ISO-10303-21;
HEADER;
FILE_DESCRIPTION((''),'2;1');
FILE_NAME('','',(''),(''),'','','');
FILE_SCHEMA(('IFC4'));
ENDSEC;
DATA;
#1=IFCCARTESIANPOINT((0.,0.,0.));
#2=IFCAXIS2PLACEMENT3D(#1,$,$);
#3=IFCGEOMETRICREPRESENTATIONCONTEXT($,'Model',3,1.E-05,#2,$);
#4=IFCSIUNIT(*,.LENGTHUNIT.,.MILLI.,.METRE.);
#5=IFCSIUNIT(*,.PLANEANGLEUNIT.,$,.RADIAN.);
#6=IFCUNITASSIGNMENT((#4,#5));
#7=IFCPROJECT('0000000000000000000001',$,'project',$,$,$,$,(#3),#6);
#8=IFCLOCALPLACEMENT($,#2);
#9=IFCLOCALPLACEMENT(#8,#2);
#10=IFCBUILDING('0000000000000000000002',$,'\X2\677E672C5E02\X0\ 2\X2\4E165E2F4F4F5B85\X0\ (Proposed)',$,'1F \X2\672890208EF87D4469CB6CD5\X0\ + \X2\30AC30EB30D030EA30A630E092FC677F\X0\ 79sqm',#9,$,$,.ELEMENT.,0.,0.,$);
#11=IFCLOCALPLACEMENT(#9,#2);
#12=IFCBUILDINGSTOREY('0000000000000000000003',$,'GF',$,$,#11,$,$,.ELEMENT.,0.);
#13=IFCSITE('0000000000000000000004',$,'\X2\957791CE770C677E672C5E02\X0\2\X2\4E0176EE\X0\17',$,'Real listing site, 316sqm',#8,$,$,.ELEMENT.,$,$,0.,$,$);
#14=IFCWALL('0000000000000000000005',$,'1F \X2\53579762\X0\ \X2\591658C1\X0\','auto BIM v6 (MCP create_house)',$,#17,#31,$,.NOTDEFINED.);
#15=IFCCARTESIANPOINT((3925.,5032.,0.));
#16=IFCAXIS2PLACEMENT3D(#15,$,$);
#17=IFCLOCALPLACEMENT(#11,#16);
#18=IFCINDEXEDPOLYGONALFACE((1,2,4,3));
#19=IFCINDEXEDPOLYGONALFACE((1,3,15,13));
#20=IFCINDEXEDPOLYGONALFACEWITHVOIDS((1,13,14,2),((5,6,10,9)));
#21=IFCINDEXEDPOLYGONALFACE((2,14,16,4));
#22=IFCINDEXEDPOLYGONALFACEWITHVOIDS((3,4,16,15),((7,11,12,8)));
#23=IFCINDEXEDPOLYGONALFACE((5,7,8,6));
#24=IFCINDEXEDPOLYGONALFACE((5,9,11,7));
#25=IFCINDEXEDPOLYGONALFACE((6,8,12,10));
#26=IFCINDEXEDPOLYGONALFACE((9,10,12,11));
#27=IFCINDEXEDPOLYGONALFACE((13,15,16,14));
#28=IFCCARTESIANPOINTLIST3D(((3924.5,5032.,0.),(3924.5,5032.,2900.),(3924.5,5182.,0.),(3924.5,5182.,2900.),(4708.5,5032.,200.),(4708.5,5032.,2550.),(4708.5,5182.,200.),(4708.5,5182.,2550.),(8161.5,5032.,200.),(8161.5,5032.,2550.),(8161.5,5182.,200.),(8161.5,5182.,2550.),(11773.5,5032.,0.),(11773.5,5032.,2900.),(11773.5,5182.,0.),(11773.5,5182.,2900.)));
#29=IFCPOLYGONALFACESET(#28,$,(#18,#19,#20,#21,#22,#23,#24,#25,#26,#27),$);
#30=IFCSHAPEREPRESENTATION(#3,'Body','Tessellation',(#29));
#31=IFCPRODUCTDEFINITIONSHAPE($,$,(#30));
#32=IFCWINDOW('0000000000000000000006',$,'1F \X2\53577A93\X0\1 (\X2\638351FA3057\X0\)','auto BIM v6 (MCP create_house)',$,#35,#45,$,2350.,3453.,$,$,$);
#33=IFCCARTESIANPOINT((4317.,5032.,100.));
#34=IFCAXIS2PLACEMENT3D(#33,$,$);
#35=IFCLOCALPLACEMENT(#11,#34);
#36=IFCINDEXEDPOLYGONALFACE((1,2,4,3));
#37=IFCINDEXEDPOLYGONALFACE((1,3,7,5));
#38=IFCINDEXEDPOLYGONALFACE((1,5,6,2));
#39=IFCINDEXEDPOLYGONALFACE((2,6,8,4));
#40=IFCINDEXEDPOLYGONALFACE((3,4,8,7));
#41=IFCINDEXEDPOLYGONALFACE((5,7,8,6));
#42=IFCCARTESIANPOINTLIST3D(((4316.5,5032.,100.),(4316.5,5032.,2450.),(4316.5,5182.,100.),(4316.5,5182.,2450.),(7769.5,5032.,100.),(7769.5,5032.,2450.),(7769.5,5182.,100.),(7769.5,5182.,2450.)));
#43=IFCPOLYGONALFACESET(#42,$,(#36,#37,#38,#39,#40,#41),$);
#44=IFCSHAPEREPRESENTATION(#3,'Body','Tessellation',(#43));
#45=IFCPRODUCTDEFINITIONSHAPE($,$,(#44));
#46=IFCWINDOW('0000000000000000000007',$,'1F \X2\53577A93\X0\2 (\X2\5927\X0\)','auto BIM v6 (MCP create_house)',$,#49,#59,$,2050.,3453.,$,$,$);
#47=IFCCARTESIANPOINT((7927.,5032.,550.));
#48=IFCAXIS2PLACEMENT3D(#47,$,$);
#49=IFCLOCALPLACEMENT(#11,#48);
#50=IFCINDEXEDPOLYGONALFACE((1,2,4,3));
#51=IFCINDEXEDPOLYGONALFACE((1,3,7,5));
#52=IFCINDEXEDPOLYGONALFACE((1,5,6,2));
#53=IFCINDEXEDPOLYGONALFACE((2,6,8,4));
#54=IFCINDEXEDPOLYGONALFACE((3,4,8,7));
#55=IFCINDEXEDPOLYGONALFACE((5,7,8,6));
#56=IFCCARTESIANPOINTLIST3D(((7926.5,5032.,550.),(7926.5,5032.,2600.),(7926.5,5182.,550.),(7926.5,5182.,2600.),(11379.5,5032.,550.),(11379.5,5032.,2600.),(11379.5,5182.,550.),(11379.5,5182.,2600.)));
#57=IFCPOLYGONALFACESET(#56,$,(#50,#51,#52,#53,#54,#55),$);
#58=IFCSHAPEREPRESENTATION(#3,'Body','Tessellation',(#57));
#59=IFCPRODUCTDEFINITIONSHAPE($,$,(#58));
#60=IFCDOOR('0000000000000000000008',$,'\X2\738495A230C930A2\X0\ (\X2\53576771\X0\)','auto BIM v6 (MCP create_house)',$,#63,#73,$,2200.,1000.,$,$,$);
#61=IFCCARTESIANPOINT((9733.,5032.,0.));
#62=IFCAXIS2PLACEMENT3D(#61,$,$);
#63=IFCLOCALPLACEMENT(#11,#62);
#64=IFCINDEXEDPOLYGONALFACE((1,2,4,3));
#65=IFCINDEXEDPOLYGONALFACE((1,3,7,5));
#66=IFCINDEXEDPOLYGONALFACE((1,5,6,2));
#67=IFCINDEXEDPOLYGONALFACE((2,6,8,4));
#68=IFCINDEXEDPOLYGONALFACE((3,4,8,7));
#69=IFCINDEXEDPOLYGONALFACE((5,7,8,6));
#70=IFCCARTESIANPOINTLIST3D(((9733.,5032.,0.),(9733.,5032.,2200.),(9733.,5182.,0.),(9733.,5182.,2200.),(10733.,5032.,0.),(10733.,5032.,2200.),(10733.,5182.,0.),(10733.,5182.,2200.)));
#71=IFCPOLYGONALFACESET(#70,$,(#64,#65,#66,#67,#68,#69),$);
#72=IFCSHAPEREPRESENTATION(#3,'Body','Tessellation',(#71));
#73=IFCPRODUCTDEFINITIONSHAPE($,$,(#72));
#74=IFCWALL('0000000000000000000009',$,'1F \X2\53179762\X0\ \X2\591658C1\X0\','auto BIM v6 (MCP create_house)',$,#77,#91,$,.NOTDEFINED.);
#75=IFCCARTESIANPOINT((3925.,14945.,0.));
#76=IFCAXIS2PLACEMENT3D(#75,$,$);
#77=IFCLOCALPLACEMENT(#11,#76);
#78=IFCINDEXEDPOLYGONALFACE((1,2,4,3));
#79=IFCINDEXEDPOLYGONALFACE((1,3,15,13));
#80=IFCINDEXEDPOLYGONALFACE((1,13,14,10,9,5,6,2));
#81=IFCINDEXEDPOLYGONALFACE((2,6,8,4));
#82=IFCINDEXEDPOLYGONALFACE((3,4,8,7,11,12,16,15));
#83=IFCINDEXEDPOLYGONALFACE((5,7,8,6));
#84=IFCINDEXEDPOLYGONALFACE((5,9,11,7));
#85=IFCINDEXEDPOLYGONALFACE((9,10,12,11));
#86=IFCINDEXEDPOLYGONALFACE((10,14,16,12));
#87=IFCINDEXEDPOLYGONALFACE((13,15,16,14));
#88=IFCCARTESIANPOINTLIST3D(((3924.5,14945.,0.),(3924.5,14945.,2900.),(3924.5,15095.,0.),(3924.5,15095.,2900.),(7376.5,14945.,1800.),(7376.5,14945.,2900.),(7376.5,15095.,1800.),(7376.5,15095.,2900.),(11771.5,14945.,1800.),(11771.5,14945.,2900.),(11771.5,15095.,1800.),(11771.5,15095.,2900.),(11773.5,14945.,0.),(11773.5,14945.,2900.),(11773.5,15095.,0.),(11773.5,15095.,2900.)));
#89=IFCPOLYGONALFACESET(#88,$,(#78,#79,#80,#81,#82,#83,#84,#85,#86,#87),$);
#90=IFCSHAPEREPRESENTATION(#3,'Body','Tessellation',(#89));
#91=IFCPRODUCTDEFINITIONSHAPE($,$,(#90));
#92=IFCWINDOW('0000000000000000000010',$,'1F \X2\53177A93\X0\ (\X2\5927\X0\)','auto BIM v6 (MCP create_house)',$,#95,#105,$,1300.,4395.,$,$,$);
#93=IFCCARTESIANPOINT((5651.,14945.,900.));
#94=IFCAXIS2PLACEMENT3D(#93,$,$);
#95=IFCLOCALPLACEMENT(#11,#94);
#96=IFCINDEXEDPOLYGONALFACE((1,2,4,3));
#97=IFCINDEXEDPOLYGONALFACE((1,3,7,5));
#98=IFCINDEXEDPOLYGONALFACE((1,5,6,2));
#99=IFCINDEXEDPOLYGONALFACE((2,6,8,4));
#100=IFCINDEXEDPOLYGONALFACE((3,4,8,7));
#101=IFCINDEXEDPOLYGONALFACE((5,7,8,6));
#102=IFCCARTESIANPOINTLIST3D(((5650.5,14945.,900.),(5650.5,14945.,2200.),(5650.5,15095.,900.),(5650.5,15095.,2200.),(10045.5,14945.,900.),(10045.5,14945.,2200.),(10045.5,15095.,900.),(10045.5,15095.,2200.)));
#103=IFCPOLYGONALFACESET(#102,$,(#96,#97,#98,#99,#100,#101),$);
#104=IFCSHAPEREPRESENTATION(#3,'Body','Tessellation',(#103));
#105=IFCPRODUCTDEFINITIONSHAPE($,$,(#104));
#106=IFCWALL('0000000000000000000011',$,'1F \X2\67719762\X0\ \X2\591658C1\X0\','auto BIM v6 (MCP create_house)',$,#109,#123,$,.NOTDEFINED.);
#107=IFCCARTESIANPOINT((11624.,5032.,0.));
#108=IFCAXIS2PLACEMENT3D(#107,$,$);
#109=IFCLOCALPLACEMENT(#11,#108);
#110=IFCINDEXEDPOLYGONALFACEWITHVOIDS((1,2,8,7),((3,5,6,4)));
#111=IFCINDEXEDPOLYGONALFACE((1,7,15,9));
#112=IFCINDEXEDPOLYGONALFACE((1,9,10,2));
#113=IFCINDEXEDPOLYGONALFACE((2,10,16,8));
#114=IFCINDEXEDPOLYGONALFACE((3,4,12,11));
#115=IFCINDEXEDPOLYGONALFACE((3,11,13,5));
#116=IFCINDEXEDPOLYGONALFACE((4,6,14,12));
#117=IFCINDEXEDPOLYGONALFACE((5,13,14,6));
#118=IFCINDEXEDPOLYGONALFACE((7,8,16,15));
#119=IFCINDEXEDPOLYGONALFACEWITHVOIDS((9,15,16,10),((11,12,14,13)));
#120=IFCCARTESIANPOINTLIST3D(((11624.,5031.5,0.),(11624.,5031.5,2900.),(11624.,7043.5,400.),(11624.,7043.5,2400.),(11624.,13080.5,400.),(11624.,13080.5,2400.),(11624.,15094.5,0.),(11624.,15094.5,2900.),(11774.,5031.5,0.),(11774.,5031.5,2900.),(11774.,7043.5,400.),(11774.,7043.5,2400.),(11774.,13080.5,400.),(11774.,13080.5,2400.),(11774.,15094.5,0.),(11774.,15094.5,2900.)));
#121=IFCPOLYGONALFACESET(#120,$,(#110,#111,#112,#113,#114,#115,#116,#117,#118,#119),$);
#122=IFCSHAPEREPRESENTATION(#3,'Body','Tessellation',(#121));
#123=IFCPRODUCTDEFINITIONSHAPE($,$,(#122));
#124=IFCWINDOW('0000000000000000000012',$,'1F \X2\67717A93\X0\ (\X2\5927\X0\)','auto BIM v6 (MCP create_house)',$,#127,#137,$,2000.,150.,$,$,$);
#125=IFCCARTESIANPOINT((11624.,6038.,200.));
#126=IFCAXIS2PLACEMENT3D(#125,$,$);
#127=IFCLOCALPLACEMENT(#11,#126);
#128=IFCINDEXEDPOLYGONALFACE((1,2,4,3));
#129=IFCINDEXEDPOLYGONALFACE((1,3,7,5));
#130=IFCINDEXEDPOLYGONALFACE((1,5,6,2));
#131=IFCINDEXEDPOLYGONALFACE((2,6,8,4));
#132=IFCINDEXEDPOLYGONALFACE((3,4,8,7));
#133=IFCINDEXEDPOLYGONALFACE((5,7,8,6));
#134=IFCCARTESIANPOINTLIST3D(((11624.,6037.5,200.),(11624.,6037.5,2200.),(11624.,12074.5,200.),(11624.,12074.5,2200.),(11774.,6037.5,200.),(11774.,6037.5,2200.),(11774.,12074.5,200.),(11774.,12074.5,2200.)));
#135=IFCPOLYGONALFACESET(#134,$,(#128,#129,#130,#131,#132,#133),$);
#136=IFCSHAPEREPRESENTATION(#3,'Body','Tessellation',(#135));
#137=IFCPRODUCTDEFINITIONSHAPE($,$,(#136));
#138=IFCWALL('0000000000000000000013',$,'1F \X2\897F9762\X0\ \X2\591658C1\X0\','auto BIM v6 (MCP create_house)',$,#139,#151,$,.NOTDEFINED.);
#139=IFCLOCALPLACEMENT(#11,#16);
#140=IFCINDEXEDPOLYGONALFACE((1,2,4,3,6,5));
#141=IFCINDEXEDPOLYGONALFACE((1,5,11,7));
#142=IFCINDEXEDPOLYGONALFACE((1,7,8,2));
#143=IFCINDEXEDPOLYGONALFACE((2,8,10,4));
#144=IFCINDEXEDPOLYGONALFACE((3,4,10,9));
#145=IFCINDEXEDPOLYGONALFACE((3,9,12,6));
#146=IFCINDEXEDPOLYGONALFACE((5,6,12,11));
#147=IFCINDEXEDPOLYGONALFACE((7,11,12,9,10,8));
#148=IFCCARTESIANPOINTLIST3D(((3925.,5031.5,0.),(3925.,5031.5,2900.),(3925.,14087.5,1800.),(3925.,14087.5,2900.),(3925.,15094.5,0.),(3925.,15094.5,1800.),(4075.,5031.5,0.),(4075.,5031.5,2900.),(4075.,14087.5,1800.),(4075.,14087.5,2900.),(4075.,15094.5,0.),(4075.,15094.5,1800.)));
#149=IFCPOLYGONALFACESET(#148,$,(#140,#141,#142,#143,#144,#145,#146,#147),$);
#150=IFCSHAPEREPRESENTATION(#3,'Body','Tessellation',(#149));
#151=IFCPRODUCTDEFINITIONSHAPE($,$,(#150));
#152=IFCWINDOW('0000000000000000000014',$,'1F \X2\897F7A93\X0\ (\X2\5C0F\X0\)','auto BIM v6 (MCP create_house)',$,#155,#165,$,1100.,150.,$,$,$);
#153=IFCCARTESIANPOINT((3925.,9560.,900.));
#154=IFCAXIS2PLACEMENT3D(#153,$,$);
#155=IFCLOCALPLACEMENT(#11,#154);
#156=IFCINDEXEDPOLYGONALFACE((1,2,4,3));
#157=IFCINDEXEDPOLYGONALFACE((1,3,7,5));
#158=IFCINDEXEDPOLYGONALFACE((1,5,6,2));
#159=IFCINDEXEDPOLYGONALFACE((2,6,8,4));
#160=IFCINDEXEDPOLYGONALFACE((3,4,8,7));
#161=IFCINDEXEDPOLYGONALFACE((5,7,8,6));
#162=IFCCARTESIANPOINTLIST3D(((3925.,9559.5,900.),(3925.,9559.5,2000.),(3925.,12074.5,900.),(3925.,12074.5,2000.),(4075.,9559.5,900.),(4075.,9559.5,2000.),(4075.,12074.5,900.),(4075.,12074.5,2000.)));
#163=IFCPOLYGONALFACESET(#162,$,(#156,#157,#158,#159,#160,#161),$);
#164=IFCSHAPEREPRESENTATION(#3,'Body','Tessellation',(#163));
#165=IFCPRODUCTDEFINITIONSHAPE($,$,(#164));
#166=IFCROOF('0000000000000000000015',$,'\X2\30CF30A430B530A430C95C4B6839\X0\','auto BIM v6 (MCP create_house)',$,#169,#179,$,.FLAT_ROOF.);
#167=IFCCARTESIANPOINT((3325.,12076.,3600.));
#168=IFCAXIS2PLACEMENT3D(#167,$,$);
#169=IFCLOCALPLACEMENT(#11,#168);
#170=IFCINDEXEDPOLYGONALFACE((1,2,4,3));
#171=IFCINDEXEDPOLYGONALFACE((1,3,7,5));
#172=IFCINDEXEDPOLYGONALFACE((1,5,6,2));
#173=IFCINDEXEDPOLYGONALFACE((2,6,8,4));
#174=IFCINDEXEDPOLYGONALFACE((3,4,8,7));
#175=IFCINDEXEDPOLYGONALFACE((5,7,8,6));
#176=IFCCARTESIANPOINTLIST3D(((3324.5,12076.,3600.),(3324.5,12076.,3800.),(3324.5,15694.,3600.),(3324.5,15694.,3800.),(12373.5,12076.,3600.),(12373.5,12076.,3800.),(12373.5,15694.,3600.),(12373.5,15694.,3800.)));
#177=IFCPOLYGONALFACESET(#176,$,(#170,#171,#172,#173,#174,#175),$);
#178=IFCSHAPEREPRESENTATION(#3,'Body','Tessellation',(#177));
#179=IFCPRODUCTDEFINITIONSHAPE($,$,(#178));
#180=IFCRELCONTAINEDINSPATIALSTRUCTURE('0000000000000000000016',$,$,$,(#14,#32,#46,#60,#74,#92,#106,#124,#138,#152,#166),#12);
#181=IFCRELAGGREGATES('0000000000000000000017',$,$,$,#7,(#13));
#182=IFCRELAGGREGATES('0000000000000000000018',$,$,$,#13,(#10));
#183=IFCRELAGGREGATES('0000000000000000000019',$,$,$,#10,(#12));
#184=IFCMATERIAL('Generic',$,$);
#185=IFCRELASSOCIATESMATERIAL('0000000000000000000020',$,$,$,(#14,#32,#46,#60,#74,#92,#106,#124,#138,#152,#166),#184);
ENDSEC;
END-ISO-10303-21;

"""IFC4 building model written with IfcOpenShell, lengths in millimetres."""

from ifc_helpers import new_model, si_unit, frame, frame_2d, origin, place, context, project, spatial, rectangle, extrude, material, element, fill, save


model = new_model("IFC4")

# Units and contexts
model_context = context("Model", 3, precision=1e-05, world=origin())
ifc_project = project(units=[si_unit("LENGTHUNIT", "METRE", prefix="MILLI"), si_unit("PLANEANGLEUNIT", "RADIAN")], contexts=[model_context])

# Site, building, storey
site_placement = place(None, origin())
site = spatial("IfcSite", under=ifc_project, at=site_placement, Name="長野県松本市2丁目17", ObjectType="Real listing site, 316sqm", CompositionType="ELEMENT", RefElevation=0.0)
building_placement = place(site_placement, origin())
building = spatial("IfcBuilding", under=site, at=building_placement, Name="松本市 2世帯住宅 (Proposed)", ObjectType="1F 木造軸組構法 + ガルバリウム鋼板 79sqm", CompositionType="ELEMENT", ElevationOfRefHeight=0.0, ElevationOfTerrain=0.0)
storey_placement = place(building_placement, origin())
storey = spatial("IfcBuildingStorey", under=building, at=storey_placement, Name="GF", CompositionType="ELEMENT", Elevation=0.0)

# Shared definitions
ifc_material = material(Name="Generic")

# Wall, openings, windows, door
wall_1_placement = place(storey_placement, frame((3925.0, 5032.0, 0.0)))
wall_1 = element("IfcWall", 1, at=wall_1_placement, inside=storey, material=ifc_material, Name="1F 南面 外壁", Description="auto BIM v6 (MCP create_house)", PredefinedType="NOTDEFINED", context=model_context, shape_type="SweptSolid", body=[
    extrude(rectangle(XDim=7849.0, YDim=150.0, at=frame_2d((3924.0, 75.0))), frame((3925.0, 5032.0, 0.0)), (0.0, 0.0, 1.0), 2900.0),
])
opening_1_placement = place(storey_placement, frame((4317.0, 5032.0, 100.0)))
opening_1 = element("IfcOpeningElement", 2, at=opening_1_placement, cuts=wall_1, PredefinedType="NOTDEFINED", context=model_context, shape_type="SweptSolid", body=[
    extrude(rectangle(XDim=3453.0, YDim=150.0, at=frame_2d((1726.0, 75.0))), frame((4317.0, 5032.0, 100.0)), (0.0, 0.0, 1.0), 2350.0),
])
opening_2_placement = place(storey_placement, frame((7927.0, 5032.0, 550.0)))
opening_2 = element("IfcOpeningElement", 3, at=opening_2_placement, cuts=wall_1, PredefinedType="NOTDEFINED", context=model_context, shape_type="SweptSolid", body=[
    extrude(rectangle(XDim=3453.0, YDim=150.0, at=frame_2d((1726.0, 75.0))), frame((7927.0, 5032.0, 550.0)), (0.0, 0.0, 1.0), 2050.0),
])
opening_3_placement = place(storey_placement, frame((9733.0, 5032.0, 0.0)))
opening_3 = element("IfcOpeningElement", 4, at=opening_3_placement, cuts=wall_1, PredefinedType="NOTDEFINED", context=model_context, shape_type="SweptSolid", body=[
    extrude(rectangle(XDim=1000.0, YDim=150.0, at=frame_2d((500.0, 75.0))), frame((9733.0, 5032.0, 0.0)), (0.0, 0.0, 1.0), 2200.0),
])
window_1_placement = place(storey_placement, frame((4317.0, 5032.0, 100.0)))
window_1 = element("IfcWindow", 5, at=window_1_placement, inside=storey, material=ifc_material, Name="1F 南窓1 (掃出し)", Description="auto BIM v6 (MCP create_house)", OverallHeight=2350.0, OverallWidth=3453.0, context=model_context, shape_type="SweptSolid", body=[
    extrude(rectangle(XDim=3453.0, YDim=150.0, at=frame_2d((1726.0, 75.0))), frame((4317.0, 5032.0, 100.0)), (0.0, 0.0, 1.0), 2350.0),
])
fill(opening_1, window_1)
window_2_placement = place(storey_placement, frame((7927.0, 5032.0, 550.0)))
window_2 = element("IfcWindow", 6, at=window_2_placement, inside=storey, material=ifc_material, Name="1F 南窓2 (大)", Description="auto BIM v6 (MCP create_house)", OverallHeight=2050.0, OverallWidth=3453.0, context=model_context, shape_type="SweptSolid", body=[
    extrude(rectangle(XDim=3453.0, YDim=150.0, at=frame_2d((1726.0, 75.0))), frame((7927.0, 5032.0, 550.0)), (0.0, 0.0, 1.0), 2050.0),
])
fill(opening_2, window_2)
door_placement = place(storey_placement, frame((9733.0, 5032.0, 0.0)))
door = element("IfcDoor", 7, at=door_placement, inside=storey, material=ifc_material, Name="玄関ドア (南東)", Description="auto BIM v6 (MCP create_house)", OverallHeight=2200.0, OverallWidth=1000.0, context=model_context, shape_type="SweptSolid", body=[
    extrude(rectangle(XDim=1000.0, YDim=150.0, at=frame_2d((500.0, 75.0))), frame((9733.0, 5032.0, 0.0)), (0.0, 0.0, 1.0), 2200.0),
])
fill(opening_3, door)

# Walls, openings, windows
wall_2_placement = place(storey_placement, frame((3925.0, 14945.0, 0.0)))
wall_2 = element("IfcWall", 8, at=wall_2_placement, inside=storey, material=ifc_material, Name="1F 北面 外壁", Description="auto BIM v6 (MCP create_house)", PredefinedType="NOTDEFINED", context=model_context, shape_type="SweptSolid", body=[
    extrude(rectangle(XDim=7849.0, YDim=150.0, at=frame_2d((3924.0, 75.0))), frame((3925.0, 14945.0, 0.0)), (0.0, 0.0, 1.0), 2900.0),
])
opening_4_placement = place(storey_placement, frame((5651.0, 14945.0, 900.0)))
opening_4 = element("IfcOpeningElement", 9, at=opening_4_placement, cuts=wall_2, PredefinedType="NOTDEFINED", context=model_context, shape_type="SweptSolid", body=[
    extrude(rectangle(XDim=4395.0, YDim=150.0, at=frame_2d((2197.0, 75.0))), frame((5651.0, 14945.0, 900.0)), (0.0, 0.0, 1.0), 1300.0),
])
window_3_placement = place(storey_placement, frame((5651.0, 14945.0, 900.0)))
window_3 = element("IfcWindow", 10, at=window_3_placement, inside=storey, material=ifc_material, Name="1F 北窓 (大)", Description="auto BIM v6 (MCP create_house)", OverallHeight=1300.0, OverallWidth=4395.0, context=model_context, shape_type="SweptSolid", body=[
    extrude(rectangle(XDim=4395.0, YDim=150.0, at=frame_2d((2197.0, 75.0))), frame((5651.0, 14945.0, 900.0)), (0.0, 0.0, 1.0), 1300.0),
])
fill(opening_4, window_3)
wall_3_placement = place(storey_placement, frame((11624.0, 5032.0, 0.0)))
wall_3 = element("IfcWall", 11, at=wall_3_placement, inside=storey, material=ifc_material, Name="1F 東面 外壁", Description="auto BIM v6 (MCP create_house)", PredefinedType="NOTDEFINED", context=model_context, shape_type="SweptSolid", body=[
    extrude(rectangle(XDim=150.0, YDim=10063.0, at=frame_2d((75.0, 5031.0))), frame((11624.0, 5032.0, 0.0)), (0.0, 0.0, 1.0), 2900.0),
])
opening_5_placement = place(storey_placement, frame((11624.0, 6038.0, 200.0)))
opening_5 = element("IfcOpeningElement", 12, at=opening_5_placement, cuts=wall_3, PredefinedType="NOTDEFINED", context=model_context, shape_type="SweptSolid", body=[
    extrude(rectangle(XDim=150.0, YDim=6037.0, at=frame_2d((75.0, 3018.0))), frame((11624.0, 6038.0, 200.0)), (0.0, 0.0, 1.0), 2000.0),
])
window_4_placement = place(storey_placement, frame((11624.0, 6038.0, 200.0)))
window_4 = element("IfcWindow", 13, at=window_4_placement, inside=storey, material=ifc_material, Name="1F 東窓 (大)", Description="auto BIM v6 (MCP create_house)", OverallHeight=2000.0, OverallWidth=150.0, context=model_context, shape_type="SweptSolid", body=[
    extrude(rectangle(XDim=150.0, YDim=6037.0, at=frame_2d((75.0, 3018.0))), frame((11624.0, 6038.0, 200.0)), (0.0, 0.0, 1.0), 2000.0),
])
fill(opening_5, window_4)
wall_4_placement = place(storey_placement, frame((3925.0, 5032.0, 0.0)))
wall_4 = element("IfcWall", 14, at=wall_4_placement, inside=storey, material=ifc_material, Name="1F 西面 外壁", Description="auto BIM v6 (MCP create_house)", PredefinedType="NOTDEFINED", context=model_context, shape_type="SweptSolid", body=[
    extrude(rectangle(XDim=150.0, YDim=10063.0, at=frame_2d((75.0, 5031.0))), frame((3925.0, 5032.0, 0.0)), (0.0, 0.0, 1.0), 2900.0),
])
opening_6_placement = place(storey_placement, frame((3925.0, 9560.0, 900.0)))
opening_6 = element("IfcOpeningElement", 15, at=opening_6_placement, cuts=wall_4, PredefinedType="NOTDEFINED", context=model_context, shape_type="SweptSolid", body=[
    extrude(rectangle(XDim=150.0, YDim=2515.0, at=frame_2d((75.0, 1257.0))), frame((3925.0, 9560.0, 900.0)), (0.0, 0.0, 1.0), 1100.0),
])
window_5_placement = place(storey_placement, frame((3925.0, 9560.0, 900.0)))
window_5 = element("IfcWindow", 16, at=window_5_placement, inside=storey, material=ifc_material, Name="1F 西窓 (小)", Description="auto BIM v6 (MCP create_house)", OverallHeight=1100.0, OverallWidth=150.0, context=model_context, shape_type="SweptSolid", body=[
    extrude(rectangle(XDim=150.0, YDim=2515.0, at=frame_2d((75.0, 1257.0))), frame((3925.0, 9560.0, 900.0)), (0.0, 0.0, 1.0), 1100.0),
])
fill(opening_6, window_5)

# Roof
roof_1_placement = place(storey_placement, frame((3325.0, 12076.0, 3600.0)))
element("IfcRoof", 17, at=roof_1_placement, inside=storey, material=ifc_material, Name="ハイサイド屋根", Description="auto BIM v6 (MCP create_house)", PredefinedType="FLAT_ROOF", context=model_context, shape_type="SweptSolid", body=[
    extrude(rectangle(XDim=9049.0, YDim=3618.0, at=frame_2d((4524.0, 1809.0))), frame((3325.0, 12076.0, 3600.0)), (0.0, 0.0, 1.0), 200.0),
])

save(model, "model.ifc")
